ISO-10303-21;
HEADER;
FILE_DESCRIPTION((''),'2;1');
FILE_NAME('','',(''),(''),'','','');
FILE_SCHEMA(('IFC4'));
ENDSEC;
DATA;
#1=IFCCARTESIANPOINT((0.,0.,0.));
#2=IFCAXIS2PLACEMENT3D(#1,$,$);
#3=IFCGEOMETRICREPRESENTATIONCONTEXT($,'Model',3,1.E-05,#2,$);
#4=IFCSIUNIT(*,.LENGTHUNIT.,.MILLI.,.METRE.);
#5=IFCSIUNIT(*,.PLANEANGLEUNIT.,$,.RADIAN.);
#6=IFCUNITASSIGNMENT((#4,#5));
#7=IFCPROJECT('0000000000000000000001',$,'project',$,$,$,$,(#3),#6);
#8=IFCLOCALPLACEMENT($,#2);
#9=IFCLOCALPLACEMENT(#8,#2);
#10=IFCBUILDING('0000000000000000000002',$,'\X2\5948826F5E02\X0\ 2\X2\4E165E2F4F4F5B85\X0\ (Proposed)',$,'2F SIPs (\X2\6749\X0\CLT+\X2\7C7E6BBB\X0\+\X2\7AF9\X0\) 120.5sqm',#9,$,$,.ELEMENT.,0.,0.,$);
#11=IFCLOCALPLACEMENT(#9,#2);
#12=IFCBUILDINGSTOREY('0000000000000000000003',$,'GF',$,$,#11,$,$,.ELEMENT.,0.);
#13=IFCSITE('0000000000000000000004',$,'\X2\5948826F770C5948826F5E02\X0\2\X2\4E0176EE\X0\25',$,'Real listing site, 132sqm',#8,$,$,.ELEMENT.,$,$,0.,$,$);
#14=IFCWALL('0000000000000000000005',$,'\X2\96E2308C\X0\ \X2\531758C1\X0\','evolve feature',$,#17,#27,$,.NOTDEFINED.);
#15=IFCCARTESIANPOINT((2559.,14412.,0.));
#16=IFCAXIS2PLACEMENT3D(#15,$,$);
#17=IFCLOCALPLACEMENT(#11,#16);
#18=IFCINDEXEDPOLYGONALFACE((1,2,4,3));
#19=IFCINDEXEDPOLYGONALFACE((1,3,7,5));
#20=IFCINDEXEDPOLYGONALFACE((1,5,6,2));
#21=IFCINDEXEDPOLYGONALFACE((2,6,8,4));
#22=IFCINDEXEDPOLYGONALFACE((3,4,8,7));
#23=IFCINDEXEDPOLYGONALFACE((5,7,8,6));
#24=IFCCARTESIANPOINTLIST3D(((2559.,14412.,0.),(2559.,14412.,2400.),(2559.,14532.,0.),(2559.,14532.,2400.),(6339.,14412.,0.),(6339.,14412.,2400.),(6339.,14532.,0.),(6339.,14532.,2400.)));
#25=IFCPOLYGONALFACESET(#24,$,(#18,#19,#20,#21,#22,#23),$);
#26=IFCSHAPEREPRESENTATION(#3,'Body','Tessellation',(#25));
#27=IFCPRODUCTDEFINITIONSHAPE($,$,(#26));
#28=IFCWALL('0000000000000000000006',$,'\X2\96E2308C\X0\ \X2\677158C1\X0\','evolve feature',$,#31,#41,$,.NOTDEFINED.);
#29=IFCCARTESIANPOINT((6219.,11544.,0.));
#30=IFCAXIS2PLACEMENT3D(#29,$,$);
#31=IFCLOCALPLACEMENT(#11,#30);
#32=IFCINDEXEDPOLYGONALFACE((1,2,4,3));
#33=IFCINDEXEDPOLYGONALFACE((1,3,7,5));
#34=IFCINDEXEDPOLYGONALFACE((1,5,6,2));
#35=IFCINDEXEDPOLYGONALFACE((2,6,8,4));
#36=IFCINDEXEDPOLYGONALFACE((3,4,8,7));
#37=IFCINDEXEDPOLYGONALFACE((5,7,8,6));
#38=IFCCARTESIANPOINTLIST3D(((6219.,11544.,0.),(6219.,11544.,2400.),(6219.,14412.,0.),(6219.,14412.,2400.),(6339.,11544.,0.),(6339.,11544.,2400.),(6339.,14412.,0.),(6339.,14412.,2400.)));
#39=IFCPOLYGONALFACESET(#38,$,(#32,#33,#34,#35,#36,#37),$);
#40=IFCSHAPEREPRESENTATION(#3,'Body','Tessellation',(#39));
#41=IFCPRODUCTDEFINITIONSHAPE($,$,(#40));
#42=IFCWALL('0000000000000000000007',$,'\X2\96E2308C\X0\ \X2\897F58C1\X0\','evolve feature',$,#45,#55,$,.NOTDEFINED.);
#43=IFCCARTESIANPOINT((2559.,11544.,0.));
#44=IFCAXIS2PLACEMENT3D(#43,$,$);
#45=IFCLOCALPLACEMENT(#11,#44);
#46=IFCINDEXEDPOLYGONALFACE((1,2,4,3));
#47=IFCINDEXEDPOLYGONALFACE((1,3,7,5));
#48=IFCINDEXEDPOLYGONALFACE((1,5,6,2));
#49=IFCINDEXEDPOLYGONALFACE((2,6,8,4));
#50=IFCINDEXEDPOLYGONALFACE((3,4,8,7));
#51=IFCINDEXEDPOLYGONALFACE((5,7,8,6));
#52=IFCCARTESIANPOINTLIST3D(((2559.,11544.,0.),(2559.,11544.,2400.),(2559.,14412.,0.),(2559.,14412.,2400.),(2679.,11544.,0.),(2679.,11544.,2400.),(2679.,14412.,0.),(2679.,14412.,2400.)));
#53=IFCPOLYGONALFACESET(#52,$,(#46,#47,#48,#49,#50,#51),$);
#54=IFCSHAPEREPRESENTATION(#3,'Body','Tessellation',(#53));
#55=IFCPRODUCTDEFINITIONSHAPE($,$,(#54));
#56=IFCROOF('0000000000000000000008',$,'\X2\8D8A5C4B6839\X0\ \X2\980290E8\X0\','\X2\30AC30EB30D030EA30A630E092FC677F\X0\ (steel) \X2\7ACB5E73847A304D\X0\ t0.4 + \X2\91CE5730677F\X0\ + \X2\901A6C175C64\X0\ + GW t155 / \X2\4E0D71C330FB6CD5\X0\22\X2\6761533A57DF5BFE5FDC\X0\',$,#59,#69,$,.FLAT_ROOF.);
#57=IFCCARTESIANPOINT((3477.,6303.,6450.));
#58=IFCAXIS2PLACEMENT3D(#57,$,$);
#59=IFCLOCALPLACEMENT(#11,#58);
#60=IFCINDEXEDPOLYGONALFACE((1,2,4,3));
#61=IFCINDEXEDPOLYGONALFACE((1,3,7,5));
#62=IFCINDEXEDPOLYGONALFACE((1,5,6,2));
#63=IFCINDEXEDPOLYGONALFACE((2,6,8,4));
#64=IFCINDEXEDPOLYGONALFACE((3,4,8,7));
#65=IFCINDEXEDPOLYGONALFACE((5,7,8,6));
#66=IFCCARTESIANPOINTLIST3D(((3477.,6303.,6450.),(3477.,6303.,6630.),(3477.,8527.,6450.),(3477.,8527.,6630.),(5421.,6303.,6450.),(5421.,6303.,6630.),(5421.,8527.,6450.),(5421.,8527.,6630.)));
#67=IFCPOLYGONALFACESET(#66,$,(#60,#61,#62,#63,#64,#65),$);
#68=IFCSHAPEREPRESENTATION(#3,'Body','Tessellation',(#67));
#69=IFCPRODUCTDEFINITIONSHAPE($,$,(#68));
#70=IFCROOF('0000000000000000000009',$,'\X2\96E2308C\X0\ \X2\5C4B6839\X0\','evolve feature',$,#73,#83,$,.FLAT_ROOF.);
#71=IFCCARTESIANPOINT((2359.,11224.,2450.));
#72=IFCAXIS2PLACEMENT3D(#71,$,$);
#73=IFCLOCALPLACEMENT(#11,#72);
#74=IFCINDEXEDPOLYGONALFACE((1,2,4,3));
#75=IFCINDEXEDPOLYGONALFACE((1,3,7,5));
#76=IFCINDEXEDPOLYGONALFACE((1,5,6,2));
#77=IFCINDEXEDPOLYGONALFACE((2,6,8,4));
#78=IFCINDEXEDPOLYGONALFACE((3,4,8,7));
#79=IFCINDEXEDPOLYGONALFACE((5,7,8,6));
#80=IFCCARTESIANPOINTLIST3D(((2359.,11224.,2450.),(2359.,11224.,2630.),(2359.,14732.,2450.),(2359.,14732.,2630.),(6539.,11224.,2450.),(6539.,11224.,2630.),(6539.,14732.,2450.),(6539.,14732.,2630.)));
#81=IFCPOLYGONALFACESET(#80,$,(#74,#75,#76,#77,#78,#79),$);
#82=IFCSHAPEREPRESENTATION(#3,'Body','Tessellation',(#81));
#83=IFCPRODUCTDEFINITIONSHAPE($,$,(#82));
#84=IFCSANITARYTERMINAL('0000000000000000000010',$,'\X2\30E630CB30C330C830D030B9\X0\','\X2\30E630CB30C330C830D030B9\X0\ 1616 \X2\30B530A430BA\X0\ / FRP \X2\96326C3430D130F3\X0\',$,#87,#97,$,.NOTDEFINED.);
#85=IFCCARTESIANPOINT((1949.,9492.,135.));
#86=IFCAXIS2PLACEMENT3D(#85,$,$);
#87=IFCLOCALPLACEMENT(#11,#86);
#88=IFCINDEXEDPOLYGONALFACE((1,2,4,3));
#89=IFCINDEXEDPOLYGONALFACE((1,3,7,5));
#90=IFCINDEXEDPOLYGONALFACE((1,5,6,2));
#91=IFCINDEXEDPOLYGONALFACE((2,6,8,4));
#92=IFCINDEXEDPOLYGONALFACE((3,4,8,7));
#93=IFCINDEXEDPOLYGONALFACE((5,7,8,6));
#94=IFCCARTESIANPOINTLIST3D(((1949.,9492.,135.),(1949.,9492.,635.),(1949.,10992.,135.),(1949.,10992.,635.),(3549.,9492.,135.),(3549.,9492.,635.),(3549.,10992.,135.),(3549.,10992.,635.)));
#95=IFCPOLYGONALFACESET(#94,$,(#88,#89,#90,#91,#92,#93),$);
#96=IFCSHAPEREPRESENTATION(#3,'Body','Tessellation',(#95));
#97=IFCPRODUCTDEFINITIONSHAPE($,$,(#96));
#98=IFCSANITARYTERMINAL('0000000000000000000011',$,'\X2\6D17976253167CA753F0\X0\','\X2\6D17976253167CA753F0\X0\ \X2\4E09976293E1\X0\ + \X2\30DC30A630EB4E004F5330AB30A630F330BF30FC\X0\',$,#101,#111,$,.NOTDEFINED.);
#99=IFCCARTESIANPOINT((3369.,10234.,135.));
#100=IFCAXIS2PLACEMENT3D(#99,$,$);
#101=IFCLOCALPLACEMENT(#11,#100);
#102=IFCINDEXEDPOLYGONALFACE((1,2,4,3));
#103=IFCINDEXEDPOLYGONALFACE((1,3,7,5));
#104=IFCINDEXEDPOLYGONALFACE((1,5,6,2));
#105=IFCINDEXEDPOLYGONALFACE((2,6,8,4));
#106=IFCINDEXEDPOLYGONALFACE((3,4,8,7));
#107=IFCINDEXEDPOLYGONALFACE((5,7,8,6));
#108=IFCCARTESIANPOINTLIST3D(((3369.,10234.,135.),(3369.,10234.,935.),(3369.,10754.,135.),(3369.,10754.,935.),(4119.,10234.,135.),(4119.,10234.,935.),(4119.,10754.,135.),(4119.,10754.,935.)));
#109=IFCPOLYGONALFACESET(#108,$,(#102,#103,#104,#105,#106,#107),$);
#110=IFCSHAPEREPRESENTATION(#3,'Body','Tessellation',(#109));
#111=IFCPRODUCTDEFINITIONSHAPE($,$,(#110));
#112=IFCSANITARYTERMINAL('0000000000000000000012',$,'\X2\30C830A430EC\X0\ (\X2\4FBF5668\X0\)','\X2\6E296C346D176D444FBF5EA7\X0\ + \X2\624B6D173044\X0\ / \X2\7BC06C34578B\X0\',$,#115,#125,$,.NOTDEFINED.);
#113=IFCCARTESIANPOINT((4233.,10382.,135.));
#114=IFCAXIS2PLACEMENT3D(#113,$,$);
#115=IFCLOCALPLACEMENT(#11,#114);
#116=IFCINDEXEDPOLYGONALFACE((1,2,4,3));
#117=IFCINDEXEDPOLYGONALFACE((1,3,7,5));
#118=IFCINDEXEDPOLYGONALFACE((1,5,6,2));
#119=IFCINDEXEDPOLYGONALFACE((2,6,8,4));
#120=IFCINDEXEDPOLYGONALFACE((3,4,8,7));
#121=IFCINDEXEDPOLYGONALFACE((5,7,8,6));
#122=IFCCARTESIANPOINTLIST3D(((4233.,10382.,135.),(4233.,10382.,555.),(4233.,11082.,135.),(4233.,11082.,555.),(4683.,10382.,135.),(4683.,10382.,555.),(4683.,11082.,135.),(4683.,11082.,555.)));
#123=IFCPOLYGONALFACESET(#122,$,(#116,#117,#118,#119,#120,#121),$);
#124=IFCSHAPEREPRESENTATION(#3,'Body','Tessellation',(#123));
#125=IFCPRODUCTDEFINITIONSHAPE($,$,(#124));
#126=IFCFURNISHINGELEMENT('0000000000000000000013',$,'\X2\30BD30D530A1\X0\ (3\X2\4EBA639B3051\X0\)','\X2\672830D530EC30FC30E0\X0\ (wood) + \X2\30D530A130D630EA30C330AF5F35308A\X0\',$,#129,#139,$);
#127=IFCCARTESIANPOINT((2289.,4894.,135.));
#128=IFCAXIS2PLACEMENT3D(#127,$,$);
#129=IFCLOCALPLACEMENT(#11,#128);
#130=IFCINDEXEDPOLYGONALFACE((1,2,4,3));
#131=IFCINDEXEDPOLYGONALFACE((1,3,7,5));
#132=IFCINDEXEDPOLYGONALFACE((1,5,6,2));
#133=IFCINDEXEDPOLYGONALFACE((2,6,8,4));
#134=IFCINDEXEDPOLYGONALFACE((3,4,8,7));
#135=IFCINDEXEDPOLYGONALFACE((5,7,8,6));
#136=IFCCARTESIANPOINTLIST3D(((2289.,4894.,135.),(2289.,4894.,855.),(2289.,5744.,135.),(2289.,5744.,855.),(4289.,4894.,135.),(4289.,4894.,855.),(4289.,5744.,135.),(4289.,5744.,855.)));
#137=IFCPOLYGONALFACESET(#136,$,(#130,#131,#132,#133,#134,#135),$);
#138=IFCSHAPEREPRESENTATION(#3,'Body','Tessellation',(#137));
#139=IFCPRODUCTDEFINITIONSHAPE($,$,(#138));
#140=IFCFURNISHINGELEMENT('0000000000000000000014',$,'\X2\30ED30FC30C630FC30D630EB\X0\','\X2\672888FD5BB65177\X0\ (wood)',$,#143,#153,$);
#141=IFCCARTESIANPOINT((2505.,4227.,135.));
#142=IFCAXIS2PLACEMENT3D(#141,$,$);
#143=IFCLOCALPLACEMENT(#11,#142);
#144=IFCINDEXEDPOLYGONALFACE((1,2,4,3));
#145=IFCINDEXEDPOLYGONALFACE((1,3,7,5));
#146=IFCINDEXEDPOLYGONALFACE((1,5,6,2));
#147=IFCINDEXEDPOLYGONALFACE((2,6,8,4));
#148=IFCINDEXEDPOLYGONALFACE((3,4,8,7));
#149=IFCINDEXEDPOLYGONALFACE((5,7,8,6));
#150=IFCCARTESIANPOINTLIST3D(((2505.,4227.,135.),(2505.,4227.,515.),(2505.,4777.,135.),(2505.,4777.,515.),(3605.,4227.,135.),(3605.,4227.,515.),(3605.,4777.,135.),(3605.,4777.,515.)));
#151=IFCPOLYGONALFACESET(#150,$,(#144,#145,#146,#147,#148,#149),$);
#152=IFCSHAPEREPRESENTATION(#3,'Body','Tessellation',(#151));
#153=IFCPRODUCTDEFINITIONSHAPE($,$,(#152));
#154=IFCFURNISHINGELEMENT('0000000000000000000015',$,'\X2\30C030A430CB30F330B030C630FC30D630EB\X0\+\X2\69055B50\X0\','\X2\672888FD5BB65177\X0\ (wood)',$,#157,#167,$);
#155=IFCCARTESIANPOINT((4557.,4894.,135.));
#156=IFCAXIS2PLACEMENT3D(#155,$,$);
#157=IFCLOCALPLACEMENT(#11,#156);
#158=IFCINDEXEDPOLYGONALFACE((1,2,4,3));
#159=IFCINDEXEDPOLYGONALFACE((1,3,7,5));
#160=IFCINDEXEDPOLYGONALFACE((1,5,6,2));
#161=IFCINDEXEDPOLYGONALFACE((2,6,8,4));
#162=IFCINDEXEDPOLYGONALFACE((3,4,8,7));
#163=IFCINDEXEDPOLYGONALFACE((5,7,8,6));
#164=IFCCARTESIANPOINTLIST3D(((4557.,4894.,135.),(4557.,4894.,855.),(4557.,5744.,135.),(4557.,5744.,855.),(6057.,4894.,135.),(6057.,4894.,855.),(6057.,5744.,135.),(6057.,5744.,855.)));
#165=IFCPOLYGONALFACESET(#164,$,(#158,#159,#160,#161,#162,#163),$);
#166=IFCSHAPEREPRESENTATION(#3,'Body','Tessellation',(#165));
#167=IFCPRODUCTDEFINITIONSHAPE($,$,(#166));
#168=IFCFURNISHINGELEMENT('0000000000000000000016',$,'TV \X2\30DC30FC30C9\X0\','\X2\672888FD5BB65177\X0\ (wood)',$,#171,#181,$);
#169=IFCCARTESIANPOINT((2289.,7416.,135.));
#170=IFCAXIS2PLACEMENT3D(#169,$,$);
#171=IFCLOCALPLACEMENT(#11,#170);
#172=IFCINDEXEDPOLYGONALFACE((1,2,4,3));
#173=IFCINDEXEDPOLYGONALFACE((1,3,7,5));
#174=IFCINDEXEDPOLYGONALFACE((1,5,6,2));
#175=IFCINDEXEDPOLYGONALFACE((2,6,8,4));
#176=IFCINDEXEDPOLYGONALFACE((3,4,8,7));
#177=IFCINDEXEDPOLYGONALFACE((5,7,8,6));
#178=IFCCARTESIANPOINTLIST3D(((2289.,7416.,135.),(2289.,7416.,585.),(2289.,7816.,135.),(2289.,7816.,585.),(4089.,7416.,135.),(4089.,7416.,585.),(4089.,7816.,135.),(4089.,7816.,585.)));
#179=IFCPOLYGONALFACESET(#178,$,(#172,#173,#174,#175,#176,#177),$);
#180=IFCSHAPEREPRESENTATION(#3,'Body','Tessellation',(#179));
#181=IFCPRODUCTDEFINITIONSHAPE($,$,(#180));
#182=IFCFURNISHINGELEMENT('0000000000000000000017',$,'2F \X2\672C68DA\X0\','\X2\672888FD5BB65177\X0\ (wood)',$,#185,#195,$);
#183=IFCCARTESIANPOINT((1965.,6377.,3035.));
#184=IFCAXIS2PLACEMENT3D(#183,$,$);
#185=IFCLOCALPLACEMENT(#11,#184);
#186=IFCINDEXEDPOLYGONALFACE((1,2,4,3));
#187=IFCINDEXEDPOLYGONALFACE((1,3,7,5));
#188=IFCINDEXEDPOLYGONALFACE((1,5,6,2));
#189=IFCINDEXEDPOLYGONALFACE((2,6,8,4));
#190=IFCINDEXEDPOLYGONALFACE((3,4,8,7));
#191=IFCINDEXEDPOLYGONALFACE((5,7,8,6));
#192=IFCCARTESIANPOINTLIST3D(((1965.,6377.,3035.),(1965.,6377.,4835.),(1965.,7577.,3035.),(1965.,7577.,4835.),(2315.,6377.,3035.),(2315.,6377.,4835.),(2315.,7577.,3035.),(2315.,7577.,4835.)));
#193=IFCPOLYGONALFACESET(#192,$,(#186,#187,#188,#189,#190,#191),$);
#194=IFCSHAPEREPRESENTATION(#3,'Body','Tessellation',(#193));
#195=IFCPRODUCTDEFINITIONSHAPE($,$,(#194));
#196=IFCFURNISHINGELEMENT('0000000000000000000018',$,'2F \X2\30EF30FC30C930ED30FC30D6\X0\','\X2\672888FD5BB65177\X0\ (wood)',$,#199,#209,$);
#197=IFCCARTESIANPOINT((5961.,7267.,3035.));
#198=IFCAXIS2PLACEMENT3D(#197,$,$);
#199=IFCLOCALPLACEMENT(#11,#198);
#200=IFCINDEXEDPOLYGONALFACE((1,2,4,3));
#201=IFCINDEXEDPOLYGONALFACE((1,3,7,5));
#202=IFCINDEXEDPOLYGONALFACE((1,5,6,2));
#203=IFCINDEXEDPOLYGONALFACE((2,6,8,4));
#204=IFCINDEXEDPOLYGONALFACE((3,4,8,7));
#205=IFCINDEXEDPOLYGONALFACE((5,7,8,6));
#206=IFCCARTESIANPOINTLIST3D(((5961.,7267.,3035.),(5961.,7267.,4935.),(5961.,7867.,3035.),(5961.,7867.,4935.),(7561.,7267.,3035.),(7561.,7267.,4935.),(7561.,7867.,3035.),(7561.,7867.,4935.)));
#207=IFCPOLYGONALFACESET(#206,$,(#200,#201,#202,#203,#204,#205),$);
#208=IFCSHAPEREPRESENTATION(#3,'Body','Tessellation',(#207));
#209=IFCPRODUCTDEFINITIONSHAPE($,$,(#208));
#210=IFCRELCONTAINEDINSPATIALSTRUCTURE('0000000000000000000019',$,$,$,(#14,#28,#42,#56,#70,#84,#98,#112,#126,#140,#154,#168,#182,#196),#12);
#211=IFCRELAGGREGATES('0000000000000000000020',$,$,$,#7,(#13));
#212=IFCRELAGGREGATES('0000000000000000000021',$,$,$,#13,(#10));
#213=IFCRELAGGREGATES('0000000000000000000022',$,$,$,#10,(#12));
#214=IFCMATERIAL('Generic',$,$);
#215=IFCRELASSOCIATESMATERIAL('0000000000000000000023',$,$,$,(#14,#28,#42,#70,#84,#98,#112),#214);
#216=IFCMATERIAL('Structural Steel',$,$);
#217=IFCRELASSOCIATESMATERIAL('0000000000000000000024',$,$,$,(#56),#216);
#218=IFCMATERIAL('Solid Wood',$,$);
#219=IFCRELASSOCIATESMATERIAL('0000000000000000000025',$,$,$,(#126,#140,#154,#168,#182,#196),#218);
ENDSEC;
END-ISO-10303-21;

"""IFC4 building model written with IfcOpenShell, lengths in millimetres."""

from ifc_helpers import new_model, si_unit, frame, frame_2d, origin, place, context, project, spatial, rectangle, extrude, material, element, save


model = new_model("IFC4")

# Units and contexts
model_context = context("Model", 3, precision=1e-05, world=origin())
ifc_project = project(units=[si_unit("LENGTHUNIT", "METRE", prefix="MILLI"), si_unit("PLANEANGLEUNIT", "RADIAN")], contexts=[model_context])

# Site, building, storey
site_placement = place(None, origin())
site = spatial("IfcSite", under=ifc_project, at=site_placement, Name="奈良県奈良市2丁目25", ObjectType="Real listing site, 132sqm", CompositionType="ELEMENT", RefElevation=0.0)
building_placement = place(site_placement, origin())
building = spatial("IfcBuilding", under=site, at=building_placement, Name="奈良市 2世帯住宅 (Proposed)", ObjectType="2F SIPs (杉CLT+籾殻+竹) 120.5sqm", CompositionType="ELEMENT", ElevationOfRefHeight=0.0, ElevationOfTerrain=0.0)
storey_placement = place(building_placement, origin())
storey = spatial("IfcBuildingStorey", under=building, at=storey_placement, Name="GF", CompositionType="ELEMENT", Elevation=0.0)

# Shared definitions
ifc_material_1 = material(Name="Generic")

# Shared definitions
ifc_material_2 = material(Name="Solid Wood")

# Walls
wall_1_placement = place(storey_placement, frame((2559.0, 14412.0, 0.0)))
element("IfcWall", 1, at=wall_1_placement, inside=storey, material=ifc_material_1, Name="離れ 北壁", Description="evolve feature", PredefinedType="NOTDEFINED", context=model_context, shape_type="SweptSolid", body=[
    extrude(rectangle(XDim=3780.0, YDim=120.0, at=frame_2d((1890.0, 60.0))), frame((2559.0, 14412.0, 0.0)), (0.0, 0.0, 1.0), 2400.0),
])
wall_2_placement = place(storey_placement, frame((6219.0, 11544.0, 0.0)))
element("IfcWall", 2, at=wall_2_placement, inside=storey, material=ifc_material_1, Name="離れ 東壁", Description="evolve feature", PredefinedType="NOTDEFINED", context=model_context, shape_type="SweptSolid", body=[
    extrude(rectangle(XDim=120.0, YDim=2868.0, at=frame_2d((60.0, 1434.0))), frame((6219.0, 11544.0, 0.0)), (0.0, 0.0, 1.0), 2400.0),
])
wall_3_placement = place(storey_placement, frame((2559.0, 11544.0, 0.0)))
element("IfcWall", 3, at=wall_3_placement, inside=storey, material=ifc_material_1, Name="離れ 西壁", Description="evolve feature", PredefinedType="NOTDEFINED", context=model_context, shape_type="SweptSolid", body=[
    extrude(rectangle(XDim=120.0, YDim=2868.0, at=frame_2d((60.0, 1434.0))), frame((2559.0, 11544.0, 0.0)), (0.0, 0.0, 1.0), 2400.0),
])

# Roofs
ifc_material_3 = material(Name="Structural Steel")
roof_1_placement = place(storey_placement, frame((3477.0, 6303.0, 6450.0)))
element("IfcRoof", 4, at=roof_1_placement, inside=storey, material=ifc_material_3, Name="越屋根 頂部", Description="ガルバリウム鋼板 (steel) 立平葺き t0.4 + 野地板 + 通気層 + GW t155 / 不燃・法22条区域対応", PredefinedType="FLAT_ROOF", context=model_context, shape_type="SweptSolid", body=[
    extrude(rectangle(XDim=1944.0, YDim=2224.0, at=frame_2d((972.0, 1112.0))), frame((3477.0, 6303.0, 6450.0)), (0.0, 0.0, 1.0), 180.0),
])
roof_2_placement = place(storey_placement, frame((2359.0, 11224.0, 2450.0)))
element("IfcRoof", 5, at=roof_2_placement, inside=storey, material=ifc_material_1, Name="離れ 屋根", Description="evolve feature", PredefinedType="FLAT_ROOF", context=model_context, shape_type="SweptSolid", body=[
    extrude(rectangle(XDim=4180.0, YDim=3508.0, at=frame_2d((2090.0, 1754.0))), frame((2359.0, 11224.0, 2450.0)), (0.0, 0.0, 1.0), 180.0),
])

# Sanitary terminals
sanitary_terminal_1_placement = place(storey_placement, frame((1949.0, 9492.0, 135.0)))
element("IfcSanitaryTerminal", 6, at=sanitary_terminal_1_placement, inside=storey, material=ifc_material_1, Name="ユニットバス", Description="ユニットバス 1616 サイズ / FRP 防水パン", PredefinedType="NOTDEFINED", context=model_context, shape_type="SweptSolid", body=[
    extrude(rectangle(XDim=1600.0, YDim=1500.0, at=frame_2d((800.0, 750.0))), frame((1949.0, 9492.0, 135.0)), (0.0, 0.0, 1.0), 500.0),
])
sanitary_terminal_2_placement = place(storey_placement, frame((3369.0, 10234.0, 135.0)))
element("IfcSanitaryTerminal", 7, at=sanitary_terminal_2_placement, inside=storey, material=ifc_material_1, Name="洗面化粧台", Description="洗面化粧台 三面鏡 + ボウル一体カウンター", PredefinedType="NOTDEFINED", context=model_context, shape_type="SweptSolid", body=[
    extrude(rectangle(XDim=750.0, YDim=520.0, at=frame_2d((375.0, 260.0))), frame((3369.0, 10234.0, 135.0)), (0.0, 0.0, 1.0), 800.0),
])
sanitary_terminal_3_placement = place(storey_placement, frame((4233.0, 10382.0, 135.0)))
element("IfcSanitaryTerminal", 8, at=sanitary_terminal_3_placement, inside=storey, material=ifc_material_1, Name="トイレ (便器)", Description="温水洗浄便座 + 手洗い / 節水型", PredefinedType="NOTDEFINED", context=model_context, shape_type="SweptSolid", body=[
    extrude(rectangle(XDim=450.0, YDim=700.0, at=frame_2d((225.0, 350.0))), frame((4233.0, 10382.0, 135.0)), (0.0, 0.0, 1.0), 420.0),
])

# Furnishing elements
furnishing_1_placement = place(storey_placement, frame((2289.0, 4894.0, 135.0)))
element("IfcFurnishingElement", 9, at=furnishing_1_placement, inside=storey, material=ifc_material_2, Name="ソファ (3人掛け)", Description="木フレーム (wood) + ファブリック張り", context=model_context, shape_type="SweptSolid", body=[
    extrude(rectangle(XDim=2000.0, YDim=850.0, at=frame_2d((1000.0, 425.0))), frame((2289.0, 4894.0, 135.0)), (0.0, 0.0, 1.0), 720.0),
])
furnishing_2_placement = place(storey_placement, frame((2505.0, 4227.0, 135.0)))
element("IfcFurnishingElement", 10, at=furnishing_2_placement, inside=storey, material=ifc_material_2, Name="ローテーブル", Description="木製家具 (wood)", context=model_context, shape_type="SweptSolid", body=[
    extrude(rectangle(XDim=1100.0, YDim=550.0, at=frame_2d((550.0, 275.0))), frame((2505.0, 4227.0, 135.0)), (0.0, 0.0, 1.0), 380.0),
])
furnishing_3_placement = place(storey_placement, frame((4557.0, 4894.0, 135.0)))
element("IfcFurnishingElement", 11, at=furnishing_3_placement, inside=storey, material=ifc_material_2, Name="ダイニングテーブル+椅子", Description="木製家具 (wood)", context=model_context, shape_type="SweptSolid", body=[
    extrude(rectangle(XDim=1500.0, YDim=850.0, at=frame_2d((750.0, 425.0))), frame((4557.0, 4894.0, 135.0)), (0.0, 0.0, 1.0), 720.0),
])
furnishing_4_placement = place(storey_placement, frame((2289.0, 7416.0, 135.0)))
element("IfcFurnishingElement", 12, at=furnishing_4_placement, inside=storey, material=ifc_material_2, Name="TV ボード", Description="木製家具 (wood)", context=model_context, shape_type="SweptSolid", body=[
    extrude(rectangle(XDim=1800.0, YDim=400.0, at=frame_2d((900.0, 200.0))), frame((2289.0, 7416.0, 135.0)), (0.0, 0.0, 1.0), 450.0),
])
furnishing_5_placement = place(storey_placement, frame((1965.0, 6377.0, 3035.0)))
element("IfcFurnishingElement", 13, at=furnishing_5_placement, inside=storey, material=ifc_material_2, Name="2F 本棚", Description="木製家具 (wood)", context=model_context, shape_type="SweptSolid", body=[
    extrude(rectangle(XDim=350.0, YDim=1200.0, at=frame_2d((175.0, 600.0))), frame((1965.0, 6377.0, 3035.0)), (0.0, 0.0, 1.0), 1800.0),
])
furnishing_6_placement = place(storey_placement, frame((5961.0, 7267.0, 3035.0)))
element("IfcFurnishingElement", 14, at=furnishing_6_placement, inside=storey, material=ifc_material_2, Name="2F ワードローブ", Description="木製家具 (wood)", context=model_context, shape_type="SweptSolid", body=[
    extrude(rectangle(XDim=1600.0, YDim=600.0, at=frame_2d((800.0, 300.0))), frame((5961.0, 7267.0, 3035.0)), (0.0, 0.0, 1.0), 1900.0),
])

save(model, "model.ifc")
